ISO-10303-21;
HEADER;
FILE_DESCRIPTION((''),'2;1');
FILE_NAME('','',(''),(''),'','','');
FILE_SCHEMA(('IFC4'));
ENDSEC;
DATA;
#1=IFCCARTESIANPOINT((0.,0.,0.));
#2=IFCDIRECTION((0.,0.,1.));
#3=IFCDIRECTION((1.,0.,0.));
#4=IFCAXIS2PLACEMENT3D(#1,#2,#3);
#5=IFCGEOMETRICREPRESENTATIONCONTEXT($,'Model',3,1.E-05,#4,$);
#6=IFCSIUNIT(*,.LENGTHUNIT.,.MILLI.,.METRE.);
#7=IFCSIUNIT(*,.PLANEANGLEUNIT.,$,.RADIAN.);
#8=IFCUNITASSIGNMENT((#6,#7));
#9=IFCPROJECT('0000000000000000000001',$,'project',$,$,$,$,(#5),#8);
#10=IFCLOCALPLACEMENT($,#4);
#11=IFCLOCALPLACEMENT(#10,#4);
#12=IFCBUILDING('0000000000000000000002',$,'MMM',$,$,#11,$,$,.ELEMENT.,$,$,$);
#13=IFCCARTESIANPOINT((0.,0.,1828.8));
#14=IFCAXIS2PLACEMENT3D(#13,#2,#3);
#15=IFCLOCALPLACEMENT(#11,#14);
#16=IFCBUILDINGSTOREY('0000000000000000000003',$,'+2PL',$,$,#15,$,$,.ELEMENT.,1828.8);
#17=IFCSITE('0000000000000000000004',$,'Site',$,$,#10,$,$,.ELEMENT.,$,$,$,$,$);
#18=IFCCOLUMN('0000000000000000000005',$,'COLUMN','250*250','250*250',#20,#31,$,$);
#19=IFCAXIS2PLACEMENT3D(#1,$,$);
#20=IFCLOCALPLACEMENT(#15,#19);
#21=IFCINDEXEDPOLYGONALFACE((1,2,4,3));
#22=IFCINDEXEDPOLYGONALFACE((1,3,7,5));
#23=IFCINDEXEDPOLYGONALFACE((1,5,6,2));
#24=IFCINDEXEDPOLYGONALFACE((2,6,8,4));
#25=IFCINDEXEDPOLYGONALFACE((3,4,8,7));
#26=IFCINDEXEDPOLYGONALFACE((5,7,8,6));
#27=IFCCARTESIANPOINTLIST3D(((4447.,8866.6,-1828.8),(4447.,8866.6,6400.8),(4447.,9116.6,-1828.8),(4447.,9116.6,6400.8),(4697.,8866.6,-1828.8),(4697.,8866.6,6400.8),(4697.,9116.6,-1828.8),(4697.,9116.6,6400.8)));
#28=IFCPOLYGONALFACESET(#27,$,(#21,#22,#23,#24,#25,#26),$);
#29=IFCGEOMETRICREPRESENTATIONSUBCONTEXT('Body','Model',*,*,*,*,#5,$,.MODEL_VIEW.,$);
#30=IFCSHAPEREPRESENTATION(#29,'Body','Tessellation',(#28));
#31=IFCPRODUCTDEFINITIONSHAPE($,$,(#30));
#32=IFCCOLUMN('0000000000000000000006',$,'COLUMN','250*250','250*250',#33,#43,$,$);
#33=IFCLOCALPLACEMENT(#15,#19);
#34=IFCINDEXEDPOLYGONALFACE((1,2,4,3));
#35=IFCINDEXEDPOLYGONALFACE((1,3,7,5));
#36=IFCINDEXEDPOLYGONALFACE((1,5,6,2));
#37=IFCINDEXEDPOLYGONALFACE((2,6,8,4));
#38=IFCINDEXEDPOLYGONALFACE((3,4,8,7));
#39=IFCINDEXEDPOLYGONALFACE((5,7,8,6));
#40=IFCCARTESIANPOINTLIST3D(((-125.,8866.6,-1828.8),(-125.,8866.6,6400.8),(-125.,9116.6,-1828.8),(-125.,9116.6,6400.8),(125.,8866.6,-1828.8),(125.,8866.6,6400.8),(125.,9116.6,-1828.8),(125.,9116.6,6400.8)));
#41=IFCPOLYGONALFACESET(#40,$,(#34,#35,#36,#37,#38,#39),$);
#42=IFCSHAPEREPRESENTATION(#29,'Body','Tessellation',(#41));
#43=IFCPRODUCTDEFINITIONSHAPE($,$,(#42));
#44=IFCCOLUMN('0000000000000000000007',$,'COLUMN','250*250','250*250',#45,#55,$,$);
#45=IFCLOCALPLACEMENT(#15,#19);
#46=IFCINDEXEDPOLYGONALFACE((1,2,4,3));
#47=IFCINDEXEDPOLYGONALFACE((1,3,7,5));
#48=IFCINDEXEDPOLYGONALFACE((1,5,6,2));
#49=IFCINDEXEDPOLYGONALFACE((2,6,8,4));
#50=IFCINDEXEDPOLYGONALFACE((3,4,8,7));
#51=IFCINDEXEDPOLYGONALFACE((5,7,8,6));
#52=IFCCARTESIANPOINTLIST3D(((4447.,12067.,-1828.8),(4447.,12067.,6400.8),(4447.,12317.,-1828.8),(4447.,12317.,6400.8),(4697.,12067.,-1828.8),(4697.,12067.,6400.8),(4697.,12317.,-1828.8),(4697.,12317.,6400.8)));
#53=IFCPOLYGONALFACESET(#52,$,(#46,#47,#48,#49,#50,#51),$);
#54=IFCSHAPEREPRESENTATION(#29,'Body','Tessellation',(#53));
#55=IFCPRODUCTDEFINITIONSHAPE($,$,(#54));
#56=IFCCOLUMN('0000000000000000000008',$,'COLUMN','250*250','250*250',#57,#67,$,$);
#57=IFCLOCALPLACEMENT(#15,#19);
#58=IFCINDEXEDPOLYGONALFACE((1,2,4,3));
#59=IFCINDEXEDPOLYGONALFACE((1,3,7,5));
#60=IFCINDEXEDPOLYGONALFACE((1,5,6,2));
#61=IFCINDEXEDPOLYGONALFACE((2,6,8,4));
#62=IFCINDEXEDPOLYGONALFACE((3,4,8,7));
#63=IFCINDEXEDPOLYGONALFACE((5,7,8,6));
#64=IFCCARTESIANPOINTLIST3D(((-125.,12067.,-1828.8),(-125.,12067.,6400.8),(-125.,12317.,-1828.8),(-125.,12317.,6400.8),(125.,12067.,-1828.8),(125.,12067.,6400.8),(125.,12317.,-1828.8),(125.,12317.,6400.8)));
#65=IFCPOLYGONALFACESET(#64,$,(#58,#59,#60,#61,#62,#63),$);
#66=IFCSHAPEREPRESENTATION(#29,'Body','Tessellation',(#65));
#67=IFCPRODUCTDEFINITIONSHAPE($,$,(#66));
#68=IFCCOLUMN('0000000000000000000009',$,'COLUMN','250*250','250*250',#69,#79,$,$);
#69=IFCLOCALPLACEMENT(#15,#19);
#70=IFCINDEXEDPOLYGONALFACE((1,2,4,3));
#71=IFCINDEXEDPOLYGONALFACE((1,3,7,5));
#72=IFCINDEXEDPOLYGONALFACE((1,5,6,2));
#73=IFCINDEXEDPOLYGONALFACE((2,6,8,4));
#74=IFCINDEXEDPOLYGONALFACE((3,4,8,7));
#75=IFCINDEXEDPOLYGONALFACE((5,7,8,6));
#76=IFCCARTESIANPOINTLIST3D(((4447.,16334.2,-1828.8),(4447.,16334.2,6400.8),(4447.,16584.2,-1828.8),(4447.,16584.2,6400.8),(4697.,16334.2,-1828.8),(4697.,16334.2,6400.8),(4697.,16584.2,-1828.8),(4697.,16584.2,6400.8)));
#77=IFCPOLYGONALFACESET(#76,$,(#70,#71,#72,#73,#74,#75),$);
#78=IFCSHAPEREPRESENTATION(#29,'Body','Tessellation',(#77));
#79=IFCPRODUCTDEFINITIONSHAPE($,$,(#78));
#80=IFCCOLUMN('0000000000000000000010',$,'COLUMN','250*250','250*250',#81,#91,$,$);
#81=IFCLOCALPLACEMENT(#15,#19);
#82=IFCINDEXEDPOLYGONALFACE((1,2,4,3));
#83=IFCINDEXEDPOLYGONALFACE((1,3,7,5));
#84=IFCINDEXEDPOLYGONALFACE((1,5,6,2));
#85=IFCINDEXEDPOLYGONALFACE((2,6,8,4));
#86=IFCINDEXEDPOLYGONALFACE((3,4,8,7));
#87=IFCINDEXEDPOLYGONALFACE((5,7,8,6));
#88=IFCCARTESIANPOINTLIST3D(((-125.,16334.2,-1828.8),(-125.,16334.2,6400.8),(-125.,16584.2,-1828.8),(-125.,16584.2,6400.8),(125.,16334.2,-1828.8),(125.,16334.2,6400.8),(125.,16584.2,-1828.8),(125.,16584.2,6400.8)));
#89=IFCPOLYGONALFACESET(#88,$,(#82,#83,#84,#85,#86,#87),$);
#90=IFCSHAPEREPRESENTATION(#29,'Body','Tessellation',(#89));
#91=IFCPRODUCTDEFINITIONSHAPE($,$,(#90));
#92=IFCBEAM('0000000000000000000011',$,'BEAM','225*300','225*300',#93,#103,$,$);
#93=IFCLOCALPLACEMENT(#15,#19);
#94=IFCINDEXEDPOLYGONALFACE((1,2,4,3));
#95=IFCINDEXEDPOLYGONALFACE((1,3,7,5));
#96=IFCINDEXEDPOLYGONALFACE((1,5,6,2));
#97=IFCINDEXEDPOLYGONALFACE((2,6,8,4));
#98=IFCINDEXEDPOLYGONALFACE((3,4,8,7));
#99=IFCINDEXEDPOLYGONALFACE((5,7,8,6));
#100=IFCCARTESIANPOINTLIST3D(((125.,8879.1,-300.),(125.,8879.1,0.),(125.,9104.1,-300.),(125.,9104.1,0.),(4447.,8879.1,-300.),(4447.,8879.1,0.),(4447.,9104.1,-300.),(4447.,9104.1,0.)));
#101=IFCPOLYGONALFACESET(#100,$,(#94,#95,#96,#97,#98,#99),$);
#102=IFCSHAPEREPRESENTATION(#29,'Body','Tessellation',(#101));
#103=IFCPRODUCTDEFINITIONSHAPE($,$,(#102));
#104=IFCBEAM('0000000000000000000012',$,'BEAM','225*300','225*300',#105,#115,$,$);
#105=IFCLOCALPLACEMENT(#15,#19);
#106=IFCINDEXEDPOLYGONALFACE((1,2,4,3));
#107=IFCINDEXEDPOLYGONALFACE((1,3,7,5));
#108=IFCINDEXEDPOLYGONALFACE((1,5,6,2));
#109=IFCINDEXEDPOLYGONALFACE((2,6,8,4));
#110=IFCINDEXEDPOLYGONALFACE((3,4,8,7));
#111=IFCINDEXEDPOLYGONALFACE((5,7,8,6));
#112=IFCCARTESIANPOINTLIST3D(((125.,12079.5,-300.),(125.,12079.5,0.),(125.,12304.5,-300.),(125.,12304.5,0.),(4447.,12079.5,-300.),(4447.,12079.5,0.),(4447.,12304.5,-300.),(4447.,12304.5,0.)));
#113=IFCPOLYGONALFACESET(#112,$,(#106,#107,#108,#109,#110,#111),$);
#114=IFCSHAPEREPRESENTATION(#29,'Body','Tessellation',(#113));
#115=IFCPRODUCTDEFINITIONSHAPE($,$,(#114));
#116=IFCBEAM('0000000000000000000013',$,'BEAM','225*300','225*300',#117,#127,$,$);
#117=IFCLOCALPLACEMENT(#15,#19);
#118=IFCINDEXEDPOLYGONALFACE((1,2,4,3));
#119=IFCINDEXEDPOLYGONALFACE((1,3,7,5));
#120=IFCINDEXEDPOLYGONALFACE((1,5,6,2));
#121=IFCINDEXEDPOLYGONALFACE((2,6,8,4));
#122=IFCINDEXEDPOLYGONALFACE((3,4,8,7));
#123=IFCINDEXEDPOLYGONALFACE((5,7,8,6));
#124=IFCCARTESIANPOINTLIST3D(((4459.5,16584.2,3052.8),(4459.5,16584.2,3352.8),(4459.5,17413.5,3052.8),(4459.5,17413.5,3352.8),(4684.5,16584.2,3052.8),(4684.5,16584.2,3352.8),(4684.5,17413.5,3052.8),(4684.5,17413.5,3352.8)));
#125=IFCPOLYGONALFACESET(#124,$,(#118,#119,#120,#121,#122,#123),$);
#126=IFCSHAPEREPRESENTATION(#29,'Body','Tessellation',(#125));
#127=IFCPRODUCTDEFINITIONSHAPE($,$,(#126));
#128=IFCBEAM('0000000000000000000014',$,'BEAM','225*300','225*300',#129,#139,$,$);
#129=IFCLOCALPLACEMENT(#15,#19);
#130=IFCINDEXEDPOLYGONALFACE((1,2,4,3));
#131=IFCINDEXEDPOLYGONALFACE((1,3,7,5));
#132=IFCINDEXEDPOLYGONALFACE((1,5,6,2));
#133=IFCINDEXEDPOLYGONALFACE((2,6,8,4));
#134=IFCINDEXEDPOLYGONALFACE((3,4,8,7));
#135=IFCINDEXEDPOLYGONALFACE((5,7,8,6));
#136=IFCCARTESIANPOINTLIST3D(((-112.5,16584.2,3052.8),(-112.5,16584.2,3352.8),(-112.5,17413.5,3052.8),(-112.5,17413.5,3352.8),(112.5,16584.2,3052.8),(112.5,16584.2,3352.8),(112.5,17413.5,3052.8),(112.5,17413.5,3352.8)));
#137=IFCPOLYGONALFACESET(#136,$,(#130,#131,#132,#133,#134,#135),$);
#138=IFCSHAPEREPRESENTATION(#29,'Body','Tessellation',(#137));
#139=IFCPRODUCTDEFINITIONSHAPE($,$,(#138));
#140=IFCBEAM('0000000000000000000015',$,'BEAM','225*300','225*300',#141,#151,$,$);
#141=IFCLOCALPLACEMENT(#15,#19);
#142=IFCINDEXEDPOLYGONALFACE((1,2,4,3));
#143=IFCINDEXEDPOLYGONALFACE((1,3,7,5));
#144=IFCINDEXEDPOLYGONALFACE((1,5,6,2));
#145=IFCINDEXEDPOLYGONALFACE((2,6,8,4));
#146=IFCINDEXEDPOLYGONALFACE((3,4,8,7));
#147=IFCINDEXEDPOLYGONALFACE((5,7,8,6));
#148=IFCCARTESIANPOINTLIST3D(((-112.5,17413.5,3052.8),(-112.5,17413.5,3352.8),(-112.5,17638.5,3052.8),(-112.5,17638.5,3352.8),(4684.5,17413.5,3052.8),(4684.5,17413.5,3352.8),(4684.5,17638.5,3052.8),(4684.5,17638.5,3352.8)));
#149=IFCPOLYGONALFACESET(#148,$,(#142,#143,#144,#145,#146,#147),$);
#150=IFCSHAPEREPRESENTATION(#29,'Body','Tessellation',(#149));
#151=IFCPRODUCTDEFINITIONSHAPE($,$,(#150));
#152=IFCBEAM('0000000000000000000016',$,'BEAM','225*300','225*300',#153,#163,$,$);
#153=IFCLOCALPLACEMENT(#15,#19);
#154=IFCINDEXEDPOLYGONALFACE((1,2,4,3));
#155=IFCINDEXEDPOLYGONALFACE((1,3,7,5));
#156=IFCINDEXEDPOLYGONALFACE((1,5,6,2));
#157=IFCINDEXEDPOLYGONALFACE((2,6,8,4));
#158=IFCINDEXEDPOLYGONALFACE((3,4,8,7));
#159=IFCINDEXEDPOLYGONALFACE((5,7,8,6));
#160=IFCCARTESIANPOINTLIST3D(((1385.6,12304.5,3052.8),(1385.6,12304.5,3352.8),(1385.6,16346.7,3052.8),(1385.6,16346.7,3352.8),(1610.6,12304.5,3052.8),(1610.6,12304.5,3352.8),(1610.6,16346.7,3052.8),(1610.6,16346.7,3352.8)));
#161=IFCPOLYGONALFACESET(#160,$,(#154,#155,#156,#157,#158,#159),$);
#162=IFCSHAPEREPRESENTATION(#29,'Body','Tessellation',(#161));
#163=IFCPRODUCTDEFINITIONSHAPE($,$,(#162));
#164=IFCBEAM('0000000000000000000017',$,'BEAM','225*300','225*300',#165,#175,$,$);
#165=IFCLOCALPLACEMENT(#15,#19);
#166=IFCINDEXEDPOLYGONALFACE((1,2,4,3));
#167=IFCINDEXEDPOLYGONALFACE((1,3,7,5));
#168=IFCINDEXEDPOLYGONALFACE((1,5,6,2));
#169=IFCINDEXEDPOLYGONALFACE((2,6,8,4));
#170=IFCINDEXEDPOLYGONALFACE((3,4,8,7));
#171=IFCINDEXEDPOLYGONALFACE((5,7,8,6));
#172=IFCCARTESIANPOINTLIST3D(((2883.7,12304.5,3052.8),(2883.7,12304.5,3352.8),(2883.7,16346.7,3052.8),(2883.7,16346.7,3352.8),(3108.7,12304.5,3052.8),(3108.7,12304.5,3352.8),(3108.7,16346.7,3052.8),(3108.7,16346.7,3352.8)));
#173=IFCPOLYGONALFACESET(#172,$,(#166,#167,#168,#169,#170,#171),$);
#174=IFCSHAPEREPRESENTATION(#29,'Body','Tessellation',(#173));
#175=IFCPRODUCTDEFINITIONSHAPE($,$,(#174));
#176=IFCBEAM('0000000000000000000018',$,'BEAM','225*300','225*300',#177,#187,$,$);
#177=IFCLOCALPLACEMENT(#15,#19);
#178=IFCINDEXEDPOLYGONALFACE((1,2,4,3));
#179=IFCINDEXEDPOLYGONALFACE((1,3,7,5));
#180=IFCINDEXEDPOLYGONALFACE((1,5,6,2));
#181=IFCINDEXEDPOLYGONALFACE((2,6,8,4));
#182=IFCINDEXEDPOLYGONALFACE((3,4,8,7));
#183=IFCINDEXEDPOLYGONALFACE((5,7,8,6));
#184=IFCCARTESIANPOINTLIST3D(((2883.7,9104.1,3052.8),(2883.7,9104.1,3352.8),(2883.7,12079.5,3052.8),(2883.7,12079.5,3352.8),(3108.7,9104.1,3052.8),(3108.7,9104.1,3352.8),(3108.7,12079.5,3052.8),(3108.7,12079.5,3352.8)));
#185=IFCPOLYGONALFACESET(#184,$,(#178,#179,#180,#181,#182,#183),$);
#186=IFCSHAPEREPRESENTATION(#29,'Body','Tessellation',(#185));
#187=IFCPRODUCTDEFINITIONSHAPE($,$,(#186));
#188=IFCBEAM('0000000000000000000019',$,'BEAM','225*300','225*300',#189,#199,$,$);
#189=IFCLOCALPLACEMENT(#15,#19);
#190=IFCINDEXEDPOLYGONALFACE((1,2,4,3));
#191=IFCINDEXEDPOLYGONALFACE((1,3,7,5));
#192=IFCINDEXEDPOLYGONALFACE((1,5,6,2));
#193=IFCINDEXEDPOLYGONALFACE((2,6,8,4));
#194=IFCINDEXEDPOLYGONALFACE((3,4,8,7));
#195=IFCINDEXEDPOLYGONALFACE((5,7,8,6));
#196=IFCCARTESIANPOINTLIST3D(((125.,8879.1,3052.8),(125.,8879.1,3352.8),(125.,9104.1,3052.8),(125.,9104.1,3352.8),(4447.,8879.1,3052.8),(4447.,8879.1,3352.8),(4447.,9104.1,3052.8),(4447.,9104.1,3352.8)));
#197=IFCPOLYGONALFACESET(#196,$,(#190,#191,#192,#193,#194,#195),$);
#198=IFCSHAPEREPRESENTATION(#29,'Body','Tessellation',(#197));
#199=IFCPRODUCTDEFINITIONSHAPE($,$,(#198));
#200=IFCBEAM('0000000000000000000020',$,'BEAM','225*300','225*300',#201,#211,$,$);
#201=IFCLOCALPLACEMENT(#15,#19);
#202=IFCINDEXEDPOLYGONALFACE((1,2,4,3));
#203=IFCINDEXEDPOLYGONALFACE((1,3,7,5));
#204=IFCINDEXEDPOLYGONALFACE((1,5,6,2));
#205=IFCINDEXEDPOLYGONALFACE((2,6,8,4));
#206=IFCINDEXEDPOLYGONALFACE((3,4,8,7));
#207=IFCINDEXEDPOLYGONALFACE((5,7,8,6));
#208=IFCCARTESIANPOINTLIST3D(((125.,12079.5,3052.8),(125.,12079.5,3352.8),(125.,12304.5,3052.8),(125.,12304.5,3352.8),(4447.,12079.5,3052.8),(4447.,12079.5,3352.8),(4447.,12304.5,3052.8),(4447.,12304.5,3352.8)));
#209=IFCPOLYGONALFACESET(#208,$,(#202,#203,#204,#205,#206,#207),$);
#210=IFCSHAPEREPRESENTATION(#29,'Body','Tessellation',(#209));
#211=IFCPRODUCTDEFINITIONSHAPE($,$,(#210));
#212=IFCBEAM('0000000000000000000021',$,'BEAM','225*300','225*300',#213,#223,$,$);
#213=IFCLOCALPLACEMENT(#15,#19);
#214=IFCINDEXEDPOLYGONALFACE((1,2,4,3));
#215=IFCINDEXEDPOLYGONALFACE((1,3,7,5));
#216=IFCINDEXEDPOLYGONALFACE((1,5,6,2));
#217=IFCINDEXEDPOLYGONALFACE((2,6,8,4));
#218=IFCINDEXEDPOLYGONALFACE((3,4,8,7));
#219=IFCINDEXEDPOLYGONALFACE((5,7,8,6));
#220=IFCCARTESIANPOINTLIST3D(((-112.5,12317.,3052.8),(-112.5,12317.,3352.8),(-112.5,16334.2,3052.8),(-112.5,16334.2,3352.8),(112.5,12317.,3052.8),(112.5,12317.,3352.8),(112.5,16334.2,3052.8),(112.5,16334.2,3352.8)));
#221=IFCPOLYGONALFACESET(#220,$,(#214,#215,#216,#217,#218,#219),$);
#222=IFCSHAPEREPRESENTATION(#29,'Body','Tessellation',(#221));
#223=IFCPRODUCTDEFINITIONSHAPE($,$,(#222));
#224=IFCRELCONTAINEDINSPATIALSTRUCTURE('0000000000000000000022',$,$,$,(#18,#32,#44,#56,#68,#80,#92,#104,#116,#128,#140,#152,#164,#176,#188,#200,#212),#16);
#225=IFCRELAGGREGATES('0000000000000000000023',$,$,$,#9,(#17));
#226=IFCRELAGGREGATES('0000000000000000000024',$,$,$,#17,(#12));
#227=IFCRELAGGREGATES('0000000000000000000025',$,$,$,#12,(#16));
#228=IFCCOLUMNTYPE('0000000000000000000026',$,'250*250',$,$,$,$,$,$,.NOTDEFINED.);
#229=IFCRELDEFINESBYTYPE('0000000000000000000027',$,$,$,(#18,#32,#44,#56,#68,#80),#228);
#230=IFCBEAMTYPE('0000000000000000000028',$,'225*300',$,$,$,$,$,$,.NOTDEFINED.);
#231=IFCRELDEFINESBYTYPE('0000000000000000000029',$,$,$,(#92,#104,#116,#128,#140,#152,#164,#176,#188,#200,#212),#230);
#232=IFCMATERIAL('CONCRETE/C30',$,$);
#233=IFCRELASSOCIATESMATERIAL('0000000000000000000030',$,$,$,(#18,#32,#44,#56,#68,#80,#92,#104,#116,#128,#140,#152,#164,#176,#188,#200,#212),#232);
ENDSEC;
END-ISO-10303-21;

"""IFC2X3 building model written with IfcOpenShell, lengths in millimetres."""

from ifc_helpers import new_model, si_unit, frame, origin_with_axes, origin_2d_with_axis, place, context, subcontext, project, spatial, rectangle, extrude, material, type_object, element, save


model = new_model("IFC2X3")

# Units and contexts
model_context = context("Model", 3, precision=1e-05, world=origin_with_axes())
body_context = subcontext(model_context, "Body", "Model", "MODEL_VIEW")
ifc_project = project(units=[si_unit("LENGTHUNIT", "METRE", prefix="MILLI"), si_unit("PLANEANGLEUNIT", "RADIAN")], contexts=[model_context])

# Site, building, storey
site_placement = place(None, origin_with_axes())
site = spatial("IfcSite", under=ifc_project, at=site_placement, Name="Site", CompositionType="ELEMENT")
building_placement = place(site_placement, origin_with_axes())
building = spatial("IfcBuilding", under=site, at=building_placement, Name="MMM", CompositionType="ELEMENT")
storey_placement = place(building_placement, frame((0.0, 0.0, 1828.8), z_axis=(0.0, 0.0, 1.0), x_axis=(1.0, 0.0, 0.0)))
storey = spatial("IfcBuildingStorey", under=building, at=storey_placement, Name="+2PL", CompositionType="ELEMENT", Elevation=1828.8)

# Columns
ifc_material = material(Name="CONCRETE/C30")
column_type = type_object("IfcColumnType", Name="250*250", PredefinedType="NOTDEFINED")
for number, where, z_axis, x_axis, name in (
    (1, (4572.0, 8991.6, -1828.8), (0.0, 0.0, 1.0), (0.0, 1.0, 0.0), "COLUMN"),
    (2, (0.0, 8991.6, -1828.8), (0.0, 0.0, 1.0), (0.0, 1.0, 0.0), "COLUMN"),
    (3, (4572.0, 12192.0, -1828.8), (0.0, 0.0, 1.0), (0.0, 1.0, 0.0), "COLUMN"),
    (4, (0.0, 12192.0, -1828.8), (0.0, 0.0, 1.0), (0.0, 1.0, 0.0), "COLUMN"),
    (5, (4572.0, 16459.2, -1828.8), (0.0, 0.0, 1.0), (0.0, -1.0, 0.0), "COLUMN"),
    (6, (0.0, 16459.2, -1828.8), (0.0, 0.0, 1.0), (0.0, 1.0, 0.0), "COLUMN"),
):
    element("IfcColumn", number, at=place(storey_placement, frame(where, z_axis=z_axis, x_axis=x_axis)), inside=storey, type_object=column_type, material=ifc_material, Name=name, Description="250*250", ObjectType="250*250", context=body_context, shape_type="SweptSolid", body=[
        extrude(rectangle(XDim=250.0, YDim=250.0, at=origin_2d_with_axis()), frame((0.0, 0.0, 8229.6), z_axis=(0.0, 0.0, -1.0), x_axis=(0.0, 1.0, 0.0)), (0.0, 0.0, 1.0), 8229.6),
    ])

# Beams
beam_type_1 = type_object("IfcBeamType", Name="225*300", PredefinedType="NOTDEFINED")
for number, where, z_axis, x_axis, name in (
    (7, (125.0, 8991.6, -150.0), (0.0, 0.0, 1.0), (1.0, 0.0, 0.0), "BEAM"),
    (8, (125.0, 12192.0, -150.0), (0.0, 0.0, 1.0), (1.0, 0.0, 0.0), "BEAM"),
):
    element("IfcBeam", number, at=place(storey_placement, frame(where, z_axis=z_axis, x_axis=x_axis)), inside=storey, type_object=beam_type_1, material=ifc_material, Name=name, Description="225*300", ObjectType="225*300", context=body_context, shape_type="SweptSolid", body=[
        extrude(rectangle(XDim=225.0, YDim=300.0, at=origin_2d_with_axis()), frame((4322.0, 0.0, 0.0), z_axis=(-1.0, 0.0, 0.0), x_axis=(0.0, -1.0, 0.0)), (0.0, 0.0, 1.0), 4322.0),
    ])
for number, where, z_axis, x_axis, name in (
    (9, (4572.0, 16584.2, 3202.8), (0.0, 0.0, 1.0), (0.0, 1.0, 0.0), "BEAM"),
    (10, (0.0, 16584.2, 3202.8), (0.0, 0.0, 1.0), (0.0, 1.0, 0.0), "BEAM"),
):
    element("IfcBeam", number, at=place(storey_placement, frame(where, z_axis=z_axis, x_axis=x_axis)), inside=storey, type_object=beam_type_1, material=ifc_material, Name=name, Description="225*300", ObjectType="225*300", context=body_context, shape_type="SweptSolid", body=[
        extrude(rectangle(XDim=225.0, YDim=300.0, at=origin_2d_with_axis()), frame((829.3, 0.0, 0.0), z_axis=(-1.0, 0.0, 0.0), x_axis=(0.0, -1.0, 0.0)), (0.0, 0.0, 1.0), 829.3),
    ])
beam_1_placement = place(storey_placement, frame((-112.5, 17526.0, 3202.8), z_axis=(0.0, 0.0, 1.0), x_axis=(1.0, 0.0, 0.0)))
element("IfcBeam", 11, at=beam_1_placement, inside=storey, type_object=beam_type_1, material=ifc_material, Name="BEAM", Description="225*300", ObjectType="225*300", context=body_context, shape_type="SweptSolid", body=[
    extrude(rectangle(XDim=225.0, YDim=300.0, at=origin_2d_with_axis()), frame((4797.0, 0.0, 0.0), z_axis=(-1.0, 0.0, 0.0), x_axis=(0.0, -1.0, 0.0)), (0.0, 0.0, 1.0), 4797.0),
])
for number, where, z_axis, x_axis, name in (
    (12, (1498.1, 12304.5, 3202.8), (0.0, 0.0, 1.0), (0.0, 1.0, 0.0), "BEAM"),
    (13, (2996.2, 12304.5, 3202.8), (0.0, 0.0, 1.0), (0.0, 1.0, 0.0), "BEAM"),
):
    element("IfcBeam", number, at=place(storey_placement, frame(where, z_axis=z_axis, x_axis=x_axis)), inside=storey, type_object=beam_type_1, material=ifc_material, Name=name, Description="225*300", ObjectType="225*300", context=body_context, shape_type="SweptSolid", body=[
        extrude(rectangle(XDim=225.0, YDim=300.0, at=origin_2d_with_axis()), frame((4042.2, 0.0, 0.0), z_axis=(-1.0, 0.0, 0.0), x_axis=(0.0, -1.0, 0.0)), (0.0, 0.0, 1.0), 4042.2),
    ])
beam_2_placement = place(storey_placement, frame((2996.2, 9104.1, 3202.8), z_axis=(0.0, 0.0, 1.0), x_axis=(0.0, 1.0, 0.0)))
element("IfcBeam", 14, at=beam_2_placement, inside=storey, type_object=beam_type_1, material=ifc_material, Name="BEAM", Description="225*300", ObjectType="225*300", context=body_context, shape_type="SweptSolid", body=[
    extrude(rectangle(XDim=225.0, YDim=300.0, at=origin_2d_with_axis()), frame((2975.4, 0.0, 0.0), z_axis=(-1.0, 0.0, 0.0), x_axis=(0.0, -1.0, 0.0)), (0.0, 0.0, 1.0), 2975.4),
])
for number, where, z_axis, x_axis, name in (
    (15, (125.0, 8991.6, 3202.8), (0.0, 0.0, 1.0), (1.0, 0.0, 0.0), "BEAM"),
    (16, (125.0, 12192.0, 3202.8), (0.0, 0.0, 1.0), (1.0, 0.0, 0.0), "BEAM"),
):
    element("IfcBeam", number, at=place(storey_placement, frame(where, z_axis=z_axis, x_axis=x_axis)), inside=storey, type_object=beam_type_1, material=ifc_material, Name=name, Description="225*300", ObjectType="225*300", context=body_context, shape_type="SweptSolid", body=[
        extrude(rectangle(XDim=225.0, YDim=300.0, at=origin_2d_with_axis()), frame((4322.0, 0.0, 0.0), z_axis=(-1.0, 0.0, 0.0), x_axis=(0.0, -1.0, 0.0)), (0.0, 0.0, 1.0), 4322.0),
    ])
beam_3_placement = place(storey_placement, frame((0.0, 12317.0, 3202.8), z_axis=(0.0, 0.0, 1.0), x_axis=(0.0, 1.0, 0.0)))
element("IfcBeam", 17, at=beam_3_placement, inside=storey, type_object=beam_type_1, material=ifc_material, Name="BEAM", Description="225*300", ObjectType="225*300", context=body_context, shape_type="SweptSolid", body=[
    extrude(rectangle(XDim=225.0, YDim=300.0, at=origin_2d_with_axis()), frame((4017.2, 0.0, 0.0), z_axis=(-1.0, 0.0, 0.0), x_axis=(0.0, -1.0, 0.0)), (0.0, 0.0, 1.0), 4017.2),
])

save(model, "model.ifc")
